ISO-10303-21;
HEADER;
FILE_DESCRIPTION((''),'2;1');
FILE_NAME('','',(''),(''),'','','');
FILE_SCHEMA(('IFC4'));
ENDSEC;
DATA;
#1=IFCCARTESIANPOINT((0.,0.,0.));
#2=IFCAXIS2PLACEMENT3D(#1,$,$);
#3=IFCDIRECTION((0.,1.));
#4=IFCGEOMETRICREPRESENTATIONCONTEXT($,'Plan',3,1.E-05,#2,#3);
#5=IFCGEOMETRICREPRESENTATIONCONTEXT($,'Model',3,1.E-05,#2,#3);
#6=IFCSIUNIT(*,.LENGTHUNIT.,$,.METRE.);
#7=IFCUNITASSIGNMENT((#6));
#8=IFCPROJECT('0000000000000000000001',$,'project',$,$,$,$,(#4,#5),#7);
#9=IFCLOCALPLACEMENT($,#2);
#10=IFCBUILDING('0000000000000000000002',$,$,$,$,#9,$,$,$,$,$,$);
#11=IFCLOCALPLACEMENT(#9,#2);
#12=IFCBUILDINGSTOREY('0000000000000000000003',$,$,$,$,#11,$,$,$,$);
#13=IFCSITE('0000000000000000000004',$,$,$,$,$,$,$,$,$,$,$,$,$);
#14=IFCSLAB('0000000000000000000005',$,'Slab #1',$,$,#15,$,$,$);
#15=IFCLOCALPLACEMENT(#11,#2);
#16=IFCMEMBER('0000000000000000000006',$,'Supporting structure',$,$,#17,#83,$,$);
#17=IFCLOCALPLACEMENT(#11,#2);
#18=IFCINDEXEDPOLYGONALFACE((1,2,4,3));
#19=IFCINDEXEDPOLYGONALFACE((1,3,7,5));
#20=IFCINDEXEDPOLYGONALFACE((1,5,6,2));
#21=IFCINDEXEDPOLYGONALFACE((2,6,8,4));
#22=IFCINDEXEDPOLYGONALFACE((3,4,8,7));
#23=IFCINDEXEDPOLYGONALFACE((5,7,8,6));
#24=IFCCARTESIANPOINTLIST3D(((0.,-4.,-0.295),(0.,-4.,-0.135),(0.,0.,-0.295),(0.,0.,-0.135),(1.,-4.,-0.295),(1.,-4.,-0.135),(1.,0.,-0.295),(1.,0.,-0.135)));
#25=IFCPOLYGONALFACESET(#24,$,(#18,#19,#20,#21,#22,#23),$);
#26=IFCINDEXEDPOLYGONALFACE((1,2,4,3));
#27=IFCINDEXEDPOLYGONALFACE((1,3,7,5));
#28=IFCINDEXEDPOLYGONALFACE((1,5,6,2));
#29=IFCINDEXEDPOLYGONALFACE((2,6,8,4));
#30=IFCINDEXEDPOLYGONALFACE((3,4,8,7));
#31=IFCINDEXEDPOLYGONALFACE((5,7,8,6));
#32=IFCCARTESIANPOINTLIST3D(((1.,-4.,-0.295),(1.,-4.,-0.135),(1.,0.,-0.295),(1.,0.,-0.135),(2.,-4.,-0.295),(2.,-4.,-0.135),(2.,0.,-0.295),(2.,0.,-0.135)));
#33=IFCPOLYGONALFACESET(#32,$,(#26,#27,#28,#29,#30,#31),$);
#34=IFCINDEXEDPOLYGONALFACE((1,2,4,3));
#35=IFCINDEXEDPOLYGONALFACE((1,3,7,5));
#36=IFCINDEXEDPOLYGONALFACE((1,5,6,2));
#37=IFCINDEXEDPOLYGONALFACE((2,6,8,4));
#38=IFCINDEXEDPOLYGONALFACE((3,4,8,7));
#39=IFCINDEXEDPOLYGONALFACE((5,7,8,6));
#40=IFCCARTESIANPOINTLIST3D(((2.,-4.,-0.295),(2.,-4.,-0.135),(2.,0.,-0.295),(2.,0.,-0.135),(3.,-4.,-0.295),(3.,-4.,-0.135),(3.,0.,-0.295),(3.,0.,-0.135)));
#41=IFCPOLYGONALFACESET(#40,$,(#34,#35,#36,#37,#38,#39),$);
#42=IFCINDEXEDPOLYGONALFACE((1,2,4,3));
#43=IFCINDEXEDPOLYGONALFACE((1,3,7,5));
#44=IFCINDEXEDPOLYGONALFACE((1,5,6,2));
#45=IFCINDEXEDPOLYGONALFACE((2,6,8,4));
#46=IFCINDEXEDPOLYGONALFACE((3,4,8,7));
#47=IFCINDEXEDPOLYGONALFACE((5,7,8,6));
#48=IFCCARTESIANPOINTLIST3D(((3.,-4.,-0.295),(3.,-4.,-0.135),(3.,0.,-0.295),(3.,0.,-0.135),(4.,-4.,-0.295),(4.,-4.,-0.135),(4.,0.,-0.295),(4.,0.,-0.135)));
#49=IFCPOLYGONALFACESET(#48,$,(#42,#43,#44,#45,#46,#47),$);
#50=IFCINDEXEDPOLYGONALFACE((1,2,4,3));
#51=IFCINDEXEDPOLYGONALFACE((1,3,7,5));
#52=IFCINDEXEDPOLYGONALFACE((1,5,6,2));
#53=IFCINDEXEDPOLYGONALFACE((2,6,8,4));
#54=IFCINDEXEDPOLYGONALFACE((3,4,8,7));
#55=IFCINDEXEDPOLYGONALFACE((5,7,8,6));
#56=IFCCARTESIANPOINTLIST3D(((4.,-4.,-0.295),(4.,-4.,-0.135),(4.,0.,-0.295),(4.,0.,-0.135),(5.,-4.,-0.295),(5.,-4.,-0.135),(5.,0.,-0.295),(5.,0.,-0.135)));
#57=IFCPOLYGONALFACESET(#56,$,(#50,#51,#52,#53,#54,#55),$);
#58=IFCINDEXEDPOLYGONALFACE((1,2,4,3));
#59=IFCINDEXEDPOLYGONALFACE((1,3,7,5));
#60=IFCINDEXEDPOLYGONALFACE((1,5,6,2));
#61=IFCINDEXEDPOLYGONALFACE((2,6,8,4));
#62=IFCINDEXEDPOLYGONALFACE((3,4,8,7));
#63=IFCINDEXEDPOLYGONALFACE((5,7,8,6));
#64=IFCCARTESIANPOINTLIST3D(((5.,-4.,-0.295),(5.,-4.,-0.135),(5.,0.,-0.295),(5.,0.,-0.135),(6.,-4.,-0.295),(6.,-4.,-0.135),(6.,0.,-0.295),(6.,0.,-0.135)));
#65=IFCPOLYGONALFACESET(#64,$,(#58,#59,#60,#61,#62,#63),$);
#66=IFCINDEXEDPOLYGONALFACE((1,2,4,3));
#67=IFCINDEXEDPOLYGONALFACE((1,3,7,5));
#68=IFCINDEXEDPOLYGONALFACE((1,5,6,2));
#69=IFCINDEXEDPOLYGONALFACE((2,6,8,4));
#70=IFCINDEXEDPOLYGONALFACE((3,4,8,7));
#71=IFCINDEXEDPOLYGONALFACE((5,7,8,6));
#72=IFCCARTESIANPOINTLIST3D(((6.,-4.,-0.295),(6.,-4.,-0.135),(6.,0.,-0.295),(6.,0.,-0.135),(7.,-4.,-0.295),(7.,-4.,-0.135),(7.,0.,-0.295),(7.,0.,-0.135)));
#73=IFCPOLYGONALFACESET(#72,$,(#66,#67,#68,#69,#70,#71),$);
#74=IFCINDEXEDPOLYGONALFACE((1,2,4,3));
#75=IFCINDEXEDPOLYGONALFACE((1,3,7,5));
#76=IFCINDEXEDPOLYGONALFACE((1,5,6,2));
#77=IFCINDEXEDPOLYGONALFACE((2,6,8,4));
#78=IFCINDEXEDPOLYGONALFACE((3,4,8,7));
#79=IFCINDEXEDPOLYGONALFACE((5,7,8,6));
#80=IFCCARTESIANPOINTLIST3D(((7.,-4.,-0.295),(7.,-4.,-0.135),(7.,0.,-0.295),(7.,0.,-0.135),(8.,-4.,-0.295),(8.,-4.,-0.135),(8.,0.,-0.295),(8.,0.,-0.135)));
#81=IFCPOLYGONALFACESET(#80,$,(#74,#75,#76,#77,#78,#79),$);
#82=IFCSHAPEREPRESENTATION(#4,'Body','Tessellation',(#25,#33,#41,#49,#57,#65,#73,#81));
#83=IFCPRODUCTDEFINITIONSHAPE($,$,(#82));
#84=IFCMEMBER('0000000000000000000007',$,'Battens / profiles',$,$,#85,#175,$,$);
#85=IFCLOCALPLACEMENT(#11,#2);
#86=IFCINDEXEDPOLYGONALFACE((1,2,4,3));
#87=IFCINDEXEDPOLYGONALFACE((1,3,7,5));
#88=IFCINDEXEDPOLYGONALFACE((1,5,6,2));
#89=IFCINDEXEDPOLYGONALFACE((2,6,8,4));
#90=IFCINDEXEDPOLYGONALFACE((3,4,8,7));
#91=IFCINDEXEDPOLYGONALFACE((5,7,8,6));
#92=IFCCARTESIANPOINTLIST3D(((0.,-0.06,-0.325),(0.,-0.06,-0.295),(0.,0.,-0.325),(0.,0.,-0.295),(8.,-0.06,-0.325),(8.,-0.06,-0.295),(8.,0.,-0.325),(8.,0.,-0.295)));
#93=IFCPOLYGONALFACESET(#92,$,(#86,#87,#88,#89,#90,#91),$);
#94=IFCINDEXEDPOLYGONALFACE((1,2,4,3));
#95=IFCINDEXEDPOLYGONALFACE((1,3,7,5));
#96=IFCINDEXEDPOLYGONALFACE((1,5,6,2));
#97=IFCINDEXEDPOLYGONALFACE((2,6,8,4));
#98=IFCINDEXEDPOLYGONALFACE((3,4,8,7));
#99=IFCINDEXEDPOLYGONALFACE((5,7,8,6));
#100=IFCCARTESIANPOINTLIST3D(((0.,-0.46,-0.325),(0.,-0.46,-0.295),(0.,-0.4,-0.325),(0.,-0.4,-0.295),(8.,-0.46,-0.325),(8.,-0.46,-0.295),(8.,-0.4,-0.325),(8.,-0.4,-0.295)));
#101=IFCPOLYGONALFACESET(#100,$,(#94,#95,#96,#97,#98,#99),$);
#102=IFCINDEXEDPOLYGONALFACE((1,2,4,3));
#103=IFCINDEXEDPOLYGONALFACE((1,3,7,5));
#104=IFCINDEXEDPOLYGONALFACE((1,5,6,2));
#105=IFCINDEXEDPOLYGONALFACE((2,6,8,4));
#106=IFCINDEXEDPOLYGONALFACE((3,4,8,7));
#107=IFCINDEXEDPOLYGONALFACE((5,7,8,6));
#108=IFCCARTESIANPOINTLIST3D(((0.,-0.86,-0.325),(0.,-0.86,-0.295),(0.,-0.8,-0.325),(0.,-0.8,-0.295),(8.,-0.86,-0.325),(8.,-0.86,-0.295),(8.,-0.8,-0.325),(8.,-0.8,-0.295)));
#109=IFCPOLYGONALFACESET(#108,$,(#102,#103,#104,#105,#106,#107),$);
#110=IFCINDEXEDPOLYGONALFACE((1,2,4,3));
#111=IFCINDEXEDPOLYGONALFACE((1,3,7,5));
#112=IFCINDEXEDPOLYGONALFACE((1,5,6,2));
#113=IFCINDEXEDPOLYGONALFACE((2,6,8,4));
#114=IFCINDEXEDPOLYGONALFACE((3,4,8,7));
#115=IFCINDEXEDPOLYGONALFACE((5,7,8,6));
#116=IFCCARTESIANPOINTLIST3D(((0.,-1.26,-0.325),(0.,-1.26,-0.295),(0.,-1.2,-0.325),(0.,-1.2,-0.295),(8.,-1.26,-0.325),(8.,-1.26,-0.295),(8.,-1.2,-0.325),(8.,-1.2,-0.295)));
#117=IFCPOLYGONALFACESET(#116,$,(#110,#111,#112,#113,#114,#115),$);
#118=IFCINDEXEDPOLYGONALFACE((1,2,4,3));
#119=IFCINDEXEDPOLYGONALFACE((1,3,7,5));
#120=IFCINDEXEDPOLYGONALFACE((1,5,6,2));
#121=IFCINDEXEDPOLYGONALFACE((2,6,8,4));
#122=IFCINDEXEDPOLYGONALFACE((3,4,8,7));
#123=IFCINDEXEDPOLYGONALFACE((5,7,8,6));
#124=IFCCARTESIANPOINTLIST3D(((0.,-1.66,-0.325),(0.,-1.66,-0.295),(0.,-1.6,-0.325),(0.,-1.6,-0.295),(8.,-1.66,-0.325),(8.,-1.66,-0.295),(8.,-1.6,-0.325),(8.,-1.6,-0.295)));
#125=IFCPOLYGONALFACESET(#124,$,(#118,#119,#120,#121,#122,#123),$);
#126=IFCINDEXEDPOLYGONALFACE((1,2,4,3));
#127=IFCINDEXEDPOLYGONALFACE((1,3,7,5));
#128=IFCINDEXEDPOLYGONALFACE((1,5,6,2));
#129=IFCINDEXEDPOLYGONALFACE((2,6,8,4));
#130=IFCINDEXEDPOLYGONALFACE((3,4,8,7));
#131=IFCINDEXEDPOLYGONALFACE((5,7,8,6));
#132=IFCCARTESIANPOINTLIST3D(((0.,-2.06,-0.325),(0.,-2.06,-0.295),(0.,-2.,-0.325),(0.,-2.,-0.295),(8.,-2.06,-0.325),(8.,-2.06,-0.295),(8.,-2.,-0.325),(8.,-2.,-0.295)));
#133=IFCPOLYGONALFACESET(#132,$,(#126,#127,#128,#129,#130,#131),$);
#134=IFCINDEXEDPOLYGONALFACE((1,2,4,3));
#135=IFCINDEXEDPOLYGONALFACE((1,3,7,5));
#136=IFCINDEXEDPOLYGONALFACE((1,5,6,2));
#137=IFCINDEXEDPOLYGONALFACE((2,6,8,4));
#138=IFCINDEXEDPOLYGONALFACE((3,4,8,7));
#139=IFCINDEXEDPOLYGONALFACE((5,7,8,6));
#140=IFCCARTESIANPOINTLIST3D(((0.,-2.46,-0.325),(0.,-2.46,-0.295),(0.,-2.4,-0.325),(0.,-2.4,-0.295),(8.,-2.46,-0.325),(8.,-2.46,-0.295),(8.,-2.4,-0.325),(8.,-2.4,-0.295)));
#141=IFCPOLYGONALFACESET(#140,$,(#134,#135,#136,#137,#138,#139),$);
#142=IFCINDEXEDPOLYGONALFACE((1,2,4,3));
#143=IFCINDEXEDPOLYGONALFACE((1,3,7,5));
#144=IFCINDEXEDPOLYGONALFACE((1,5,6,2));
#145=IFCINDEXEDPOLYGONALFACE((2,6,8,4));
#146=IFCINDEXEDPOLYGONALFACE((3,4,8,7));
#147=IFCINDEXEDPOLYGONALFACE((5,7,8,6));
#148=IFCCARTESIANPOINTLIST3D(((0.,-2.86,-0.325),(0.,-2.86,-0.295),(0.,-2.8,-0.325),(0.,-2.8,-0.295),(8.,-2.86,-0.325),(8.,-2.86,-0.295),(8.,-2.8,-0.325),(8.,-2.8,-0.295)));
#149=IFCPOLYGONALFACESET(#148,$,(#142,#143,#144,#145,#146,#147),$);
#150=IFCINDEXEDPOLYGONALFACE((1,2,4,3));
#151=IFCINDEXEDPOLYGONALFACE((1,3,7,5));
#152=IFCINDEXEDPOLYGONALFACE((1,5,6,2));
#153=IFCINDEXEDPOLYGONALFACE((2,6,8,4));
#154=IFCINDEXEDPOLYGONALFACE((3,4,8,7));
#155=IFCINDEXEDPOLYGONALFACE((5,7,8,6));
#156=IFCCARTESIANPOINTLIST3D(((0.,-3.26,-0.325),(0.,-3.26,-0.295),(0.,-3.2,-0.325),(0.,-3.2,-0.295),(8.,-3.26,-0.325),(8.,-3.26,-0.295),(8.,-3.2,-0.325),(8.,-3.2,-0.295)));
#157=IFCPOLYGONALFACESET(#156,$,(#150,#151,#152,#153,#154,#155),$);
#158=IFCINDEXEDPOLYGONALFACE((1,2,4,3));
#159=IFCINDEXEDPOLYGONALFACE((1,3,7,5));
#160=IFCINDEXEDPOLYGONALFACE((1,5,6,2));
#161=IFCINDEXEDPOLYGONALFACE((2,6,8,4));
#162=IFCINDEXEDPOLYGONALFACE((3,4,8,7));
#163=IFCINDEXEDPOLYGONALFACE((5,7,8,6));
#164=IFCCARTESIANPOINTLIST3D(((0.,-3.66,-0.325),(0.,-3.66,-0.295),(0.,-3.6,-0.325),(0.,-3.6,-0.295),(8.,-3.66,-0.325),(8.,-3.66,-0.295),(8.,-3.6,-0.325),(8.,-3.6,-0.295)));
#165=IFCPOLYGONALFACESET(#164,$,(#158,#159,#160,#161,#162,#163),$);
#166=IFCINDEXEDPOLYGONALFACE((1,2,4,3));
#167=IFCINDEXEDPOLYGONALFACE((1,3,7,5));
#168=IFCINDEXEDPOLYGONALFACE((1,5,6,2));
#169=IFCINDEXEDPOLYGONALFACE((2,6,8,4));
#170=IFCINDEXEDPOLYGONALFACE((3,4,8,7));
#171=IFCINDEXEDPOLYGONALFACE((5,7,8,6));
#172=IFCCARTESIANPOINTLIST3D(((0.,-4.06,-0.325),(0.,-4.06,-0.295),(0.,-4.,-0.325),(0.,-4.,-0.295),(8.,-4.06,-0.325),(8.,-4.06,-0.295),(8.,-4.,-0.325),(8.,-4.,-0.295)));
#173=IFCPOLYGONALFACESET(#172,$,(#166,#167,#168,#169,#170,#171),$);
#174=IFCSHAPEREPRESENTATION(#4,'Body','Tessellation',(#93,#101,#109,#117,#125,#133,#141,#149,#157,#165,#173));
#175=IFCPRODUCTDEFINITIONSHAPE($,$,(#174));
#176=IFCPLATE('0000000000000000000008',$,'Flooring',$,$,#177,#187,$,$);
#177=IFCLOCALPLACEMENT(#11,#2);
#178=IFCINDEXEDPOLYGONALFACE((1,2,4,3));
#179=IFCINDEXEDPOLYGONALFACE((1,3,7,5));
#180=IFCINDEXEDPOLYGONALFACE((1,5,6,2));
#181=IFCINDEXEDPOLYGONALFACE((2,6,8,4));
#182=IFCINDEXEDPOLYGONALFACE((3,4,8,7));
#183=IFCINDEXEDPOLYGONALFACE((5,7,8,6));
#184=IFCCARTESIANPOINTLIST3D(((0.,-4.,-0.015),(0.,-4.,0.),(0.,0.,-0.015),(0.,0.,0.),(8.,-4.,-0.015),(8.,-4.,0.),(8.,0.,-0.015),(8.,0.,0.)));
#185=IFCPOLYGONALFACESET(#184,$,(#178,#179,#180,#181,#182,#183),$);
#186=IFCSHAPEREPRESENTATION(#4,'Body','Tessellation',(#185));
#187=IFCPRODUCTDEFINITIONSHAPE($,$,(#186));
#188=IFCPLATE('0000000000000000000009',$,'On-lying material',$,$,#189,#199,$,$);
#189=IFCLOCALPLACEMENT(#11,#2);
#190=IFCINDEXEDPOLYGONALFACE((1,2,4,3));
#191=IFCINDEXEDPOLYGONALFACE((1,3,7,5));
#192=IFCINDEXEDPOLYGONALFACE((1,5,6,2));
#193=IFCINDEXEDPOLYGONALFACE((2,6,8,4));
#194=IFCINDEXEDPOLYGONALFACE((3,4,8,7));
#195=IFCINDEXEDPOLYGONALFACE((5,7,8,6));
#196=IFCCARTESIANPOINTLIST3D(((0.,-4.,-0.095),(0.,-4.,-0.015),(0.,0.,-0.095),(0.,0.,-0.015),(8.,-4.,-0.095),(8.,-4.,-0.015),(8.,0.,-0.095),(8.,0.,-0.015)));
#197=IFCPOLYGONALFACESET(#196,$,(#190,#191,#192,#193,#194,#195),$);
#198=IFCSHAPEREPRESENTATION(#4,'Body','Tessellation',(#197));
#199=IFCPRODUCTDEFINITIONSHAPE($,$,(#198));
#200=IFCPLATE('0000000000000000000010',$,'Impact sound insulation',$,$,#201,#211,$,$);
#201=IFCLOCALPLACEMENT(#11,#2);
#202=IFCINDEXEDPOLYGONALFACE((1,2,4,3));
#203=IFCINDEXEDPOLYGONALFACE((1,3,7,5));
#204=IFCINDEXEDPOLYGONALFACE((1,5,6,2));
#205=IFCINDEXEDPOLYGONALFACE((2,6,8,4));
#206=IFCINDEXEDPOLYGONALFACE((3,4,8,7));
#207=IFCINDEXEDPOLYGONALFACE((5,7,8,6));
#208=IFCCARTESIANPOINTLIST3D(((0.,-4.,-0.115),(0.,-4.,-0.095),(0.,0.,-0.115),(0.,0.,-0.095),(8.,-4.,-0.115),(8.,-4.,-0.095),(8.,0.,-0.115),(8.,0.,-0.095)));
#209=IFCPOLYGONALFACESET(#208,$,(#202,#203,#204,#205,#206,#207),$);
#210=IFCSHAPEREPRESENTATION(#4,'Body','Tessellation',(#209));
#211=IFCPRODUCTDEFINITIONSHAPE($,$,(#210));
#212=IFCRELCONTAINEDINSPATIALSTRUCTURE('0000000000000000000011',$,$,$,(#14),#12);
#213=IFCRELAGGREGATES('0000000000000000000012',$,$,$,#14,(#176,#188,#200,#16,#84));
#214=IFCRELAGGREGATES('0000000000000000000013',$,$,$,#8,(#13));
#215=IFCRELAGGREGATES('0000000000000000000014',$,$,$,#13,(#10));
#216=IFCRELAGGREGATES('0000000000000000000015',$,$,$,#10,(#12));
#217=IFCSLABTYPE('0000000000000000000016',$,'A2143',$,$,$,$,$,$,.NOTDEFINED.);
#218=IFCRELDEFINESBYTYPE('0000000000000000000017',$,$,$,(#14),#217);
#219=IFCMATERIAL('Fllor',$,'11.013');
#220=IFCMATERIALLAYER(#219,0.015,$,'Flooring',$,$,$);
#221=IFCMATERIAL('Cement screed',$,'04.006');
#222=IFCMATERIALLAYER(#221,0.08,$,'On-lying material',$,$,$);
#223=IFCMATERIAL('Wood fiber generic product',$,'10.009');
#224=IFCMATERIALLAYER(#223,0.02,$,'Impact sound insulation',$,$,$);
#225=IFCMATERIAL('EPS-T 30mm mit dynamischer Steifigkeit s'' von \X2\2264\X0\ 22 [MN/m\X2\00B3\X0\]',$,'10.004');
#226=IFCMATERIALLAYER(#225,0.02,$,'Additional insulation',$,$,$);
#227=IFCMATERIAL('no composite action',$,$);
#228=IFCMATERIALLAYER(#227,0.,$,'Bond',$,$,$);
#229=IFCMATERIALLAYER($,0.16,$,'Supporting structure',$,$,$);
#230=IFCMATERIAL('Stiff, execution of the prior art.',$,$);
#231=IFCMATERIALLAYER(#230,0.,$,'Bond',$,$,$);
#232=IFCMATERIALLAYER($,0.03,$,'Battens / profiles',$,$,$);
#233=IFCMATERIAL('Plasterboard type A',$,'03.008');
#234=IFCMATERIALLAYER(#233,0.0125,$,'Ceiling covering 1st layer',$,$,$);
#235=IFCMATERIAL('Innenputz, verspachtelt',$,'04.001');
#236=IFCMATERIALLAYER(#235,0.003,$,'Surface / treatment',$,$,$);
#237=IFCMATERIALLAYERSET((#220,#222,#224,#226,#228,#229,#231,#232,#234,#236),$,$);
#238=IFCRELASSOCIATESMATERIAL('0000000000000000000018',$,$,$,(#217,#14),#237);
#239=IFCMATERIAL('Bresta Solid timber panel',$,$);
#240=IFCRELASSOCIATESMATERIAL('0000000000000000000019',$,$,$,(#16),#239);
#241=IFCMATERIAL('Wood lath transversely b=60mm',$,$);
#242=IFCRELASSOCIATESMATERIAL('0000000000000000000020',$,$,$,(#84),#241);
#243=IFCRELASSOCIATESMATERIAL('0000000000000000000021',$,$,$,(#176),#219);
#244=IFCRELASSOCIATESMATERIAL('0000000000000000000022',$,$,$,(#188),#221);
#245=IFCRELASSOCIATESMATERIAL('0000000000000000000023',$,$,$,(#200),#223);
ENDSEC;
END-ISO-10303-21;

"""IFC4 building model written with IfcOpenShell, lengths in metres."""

from ifc_helpers import new_model, si_unit, direction, frame, frame_2d, origin, origin_with_axes, place, context, project, spatial, rectangle, extrude, material, layer, layer_set, type_object, element, aggregate, save


model = new_model("IFC4")

# Units and contexts
plan_context = context("Plan", 3, precision=1e-05, world=origin(), true_north=direction((0.0, 1.0)))
model_context = context("Model", 3, precision=1e-05, world=origin(), true_north=direction((0.0, 1.0)))
ifc_project = project(units=[si_unit("LENGTHUNIT", "METRE")], contexts=[plan_context, model_context])

# Site, building, storey
site = spatial("IfcSite", under=ifc_project)
building_placement = place(None, origin())
building = spatial("IfcBuilding", under=site, at=building_placement)
storey_placement = place(building_placement, origin())
storey = spatial("IfcBuildingStorey", under=building, at=storey_placement)

# Slab, members, plates
ifc_material_1 = material(Name="Fllor", Category="11.013")
ifc_layer_1 = layer(ifc_material_1, 0.015, Name="Flooring")
ifc_material_2 = material(Name="Cement screed", Category="04.006")
ifc_layer_2 = layer(ifc_material_2, 0.08, Name="On-lying material")
ifc_material_3 = material(Name="Wood fiber generic product", Category="10.009")
ifc_layer_3 = layer(ifc_material_3, 0.02, Name="Impact sound insulation")
ifc_material_4 = material(Name="EPS-T 30mm mit dynamischer Steifigkeit s' von ≤ 22 [MN/m³]", Category="10.004")
ifc_layer_4 = layer(ifc_material_4, 0.02, Name="Additional insulation")
ifc_material_5 = material(Name="no composite action")
ifc_layer_5 = layer(ifc_material_5, 0.0, Name="Bond")
ifc_layer_6 = layer(None, 0.16, Name="Supporting structure")
ifc_material_6 = material(Name="Stiff, execution of the prior art.")
ifc_layer_7 = layer(ifc_material_6, 0.0, Name="Bond")
ifc_layer_8 = layer(None, 0.03, Name="Battens / profiles")
ifc_material_7 = material(Name="Plasterboard type A", Category="03.008")
ifc_layer_9 = layer(ifc_material_7, 0.0125, Name="Ceiling covering 1st layer")
ifc_material_8 = material(Name="Innenputz, verspachtelt", Category="04.001")
ifc_layer_10 = layer(ifc_material_8, 0.003, Name="Surface / treatment")
ifc_layer_set = layer_set([ifc_layer_1, ifc_layer_2, ifc_layer_3, ifc_layer_4, ifc_layer_5, ifc_layer_6, ifc_layer_7, ifc_layer_8, ifc_layer_9, ifc_layer_10])
slab_type = type_object("IfcSlabType", Name="A2143", PredefinedType="NOTDEFINED", material=ifc_layer_set)
slab_placement = place(None, frame((0.0, 0.0, 0.0), z_axis=(0.0, 0.0, -1.0), x_axis=(1.0, 0.0, 0.0)))
slab = element("IfcSlab", 1, at=slab_placement, inside=storey, type_object=slab_type, material=ifc_layer_set, Name="Slab #1")
ifc_material_9 = material(Name="Bresta Solid timber panel")
member_1_placement = place(slab_placement, origin())
member_1 = element("IfcMember", 2, at=member_1_placement, material=ifc_material_9, Name="Supporting structure", context=plan_context, shape_type="SweptSolid", body=[
    extrude(rectangle(XDim=1.0, YDim=0.16, at=frame_2d((0.5, 0.08), x_axis=(1.0, 0.0))), frame((0.0, 4.0, 0.135), z_axis=(0.0, -1.0, 0.0), x_axis=(1.0, 0.0, 0.0)), (0.0, 0.0, 1.0), 4.0),
    extrude(rectangle(XDim=1.0, YDim=0.16, at=frame_2d((0.5, 0.08), x_axis=(1.0, 0.0))), frame((1.0, 4.0, 0.135), z_axis=(0.0, -1.0, 0.0), x_axis=(1.0, 0.0, 0.0)), (0.0, 0.0, 1.0), 4.0),
    extrude(rectangle(XDim=1.0, YDim=0.16, at=frame_2d((0.5, 0.08), x_axis=(1.0, 0.0))), frame((2.0, 4.0, 0.135), z_axis=(0.0, -1.0, 0.0), x_axis=(1.0, 0.0, 0.0)), (0.0, 0.0, 1.0), 4.0),
    extrude(rectangle(XDim=1.0, YDim=0.16, at=frame_2d((0.5, 0.08), x_axis=(1.0, 0.0))), frame((3.0, 4.0, 0.135), z_axis=(0.0, -1.0, 0.0), x_axis=(1.0, 0.0, 0.0)), (0.0, 0.0, 1.0), 4.0),
    extrude(rectangle(XDim=1.0, YDim=0.16, at=frame_2d((0.5, 0.08), x_axis=(1.0, 0.0))), frame((4.0, 4.0, 0.135), z_axis=(0.0, -1.0, 0.0), x_axis=(1.0, 0.0, 0.0)), (0.0, 0.0, 1.0), 4.0),
    extrude(rectangle(XDim=1.0, YDim=0.16, at=frame_2d((0.5, 0.08), x_axis=(1.0, 0.0))), frame((5.0, 4.0, 0.135), z_axis=(0.0, -1.0, 0.0), x_axis=(1.0, 0.0, 0.0)), (0.0, 0.0, 1.0), 4.0),
    extrude(rectangle(XDim=1.0, YDim=0.16, at=frame_2d((0.5, 0.08), x_axis=(1.0, 0.0))), frame((6.0, 4.0, 0.135), z_axis=(0.0, -1.0, 0.0), x_axis=(1.0, 0.0, 0.0)), (0.0, 0.0, 1.0), 4.0),
    extrude(rectangle(XDim=1.0, YDim=0.16, at=frame_2d((0.5, 0.08), x_axis=(1.0, 0.0))), frame((7.0, 4.0, 0.135), z_axis=(0.0, -1.0, 0.0), x_axis=(1.0, 0.0, 0.0)), (0.0, 0.0, 1.0), 4.0),
])
ifc_material_10 = material(Name="Wood lath transversely b=60mm")
member_2_placement = place(slab_placement, origin())
member_2 = element("IfcMember", 3, at=member_2_placement, material=ifc_material_10, Name="Battens / profiles", context=plan_context, shape_type="SweptSolid", body=[
    extrude(rectangle(XDim=0.06, YDim=0.03, at=frame_2d((0.03, 0.015), x_axis=(1.0, 0.0))), frame((0.0, 0.0, 0.295), z_axis=(1.0, 0.0, 0.0), x_axis=(0.0, 1.0, 0.0)), (0.0, 0.0, 1.0), 8.0),
    extrude(rectangle(XDim=0.06, YDim=0.03, at=frame_2d((0.03, 0.015), x_axis=(1.0, 0.0))), frame((0.0, 0.4, 0.295), z_axis=(1.0, 0.0, 0.0), x_axis=(0.0, 1.0, 0.0)), (0.0, 0.0, 1.0), 8.0),
    extrude(rectangle(XDim=0.06, YDim=0.03, at=frame_2d((0.03, 0.015), x_axis=(1.0, 0.0))), frame((0.0, 0.8, 0.295), z_axis=(1.0, 0.0, 0.0), x_axis=(0.0, 1.0, 0.0)), (0.0, 0.0, 1.0), 8.0),
    extrude(rectangle(XDim=0.06, YDim=0.03, at=frame_2d((0.03, 0.015), x_axis=(1.0, 0.0))), frame((0.0, 1.2, 0.295), z_axis=(1.0, 0.0, 0.0), x_axis=(0.0, 1.0, 0.0)), (0.0, 0.0, 1.0), 8.0),
    extrude(rectangle(XDim=0.06, YDim=0.03, at=frame_2d((0.03, 0.015), x_axis=(1.0, 0.0))), frame((0.0, 1.6, 0.295), z_axis=(1.0, 0.0, 0.0), x_axis=(0.0, 1.0, 0.0)), (0.0, 0.0, 1.0), 8.0),
    extrude(rectangle(XDim=0.06, YDim=0.03, at=frame_2d((0.03, 0.015), x_axis=(1.0, 0.0))), frame((0.0, 2.0, 0.295), z_axis=(1.0, 0.0, 0.0), x_axis=(0.0, 1.0, 0.0)), (0.0, 0.0, 1.0), 8.0),
    extrude(rectangle(XDim=0.06, YDim=0.03, at=frame_2d((0.03, 0.015), x_axis=(1.0, 0.0))), frame((0.0, 2.4, 0.295), z_axis=(1.0, 0.0, 0.0), x_axis=(0.0, 1.0, 0.0)), (0.0, 0.0, 1.0), 8.0),
    extrude(rectangle(XDim=0.06, YDim=0.03, at=frame_2d((0.03, 0.015), x_axis=(1.0, 0.0))), frame((0.0, 2.8, 0.295), z_axis=(1.0, 0.0, 0.0), x_axis=(0.0, 1.0, 0.0)), (0.0, 0.0, 1.0), 8.0),
    extrude(rectangle(XDim=0.06, YDim=0.03, at=frame_2d((0.03, 0.015), x_axis=(1.0, 0.0))), frame((0.0, 3.2, 0.295), z_axis=(1.0, 0.0, 0.0), x_axis=(0.0, 1.0, 0.0)), (0.0, 0.0, 1.0), 8.0),
    extrude(rectangle(XDim=0.06, YDim=0.03, at=frame_2d((0.03, 0.015), x_axis=(1.0, 0.0))), frame((0.0, 3.6, 0.295), z_axis=(1.0, 0.0, 0.0), x_axis=(0.0, 1.0, 0.0)), (0.0, 0.0, 1.0), 8.0),
    extrude(rectangle(XDim=0.06, YDim=0.03, at=frame_2d((0.03, 0.015), x_axis=(1.0, 0.0))), frame((0.0, 4.0, 0.295), z_axis=(1.0, 0.0, 0.0), x_axis=(0.0, 1.0, 0.0)), (0.0, 0.0, 1.0), 8.0),
])
plate_1_placement = place(slab_placement, origin())
plate_1 = element("IfcPlate", 4, at=plate_1_placement, material=ifc_material_1, Name="Flooring", context=plan_context, shape_type="SweptSolid", body=[
    extrude(rectangle(XDim=8.0, YDim=4.0, at=frame_2d((4.0, 2.0), x_axis=(1.0, 0.0))), origin_with_axes(), (0.0, 0.0, 1.0), 0.015),
])
plate_2_placement = place(slab_placement, origin())
plate_2 = element("IfcPlate", 5, at=plate_2_placement, material=ifc_material_2, Name="On-lying material", context=plan_context, shape_type="SweptSolid", body=[
    extrude(rectangle(XDim=8.0, YDim=4.0, at=frame_2d((4.0, 2.0), x_axis=(1.0, 0.0))), frame((0.0, 0.0, 0.015), z_axis=(0.0, 0.0, 1.0), x_axis=(1.0, 0.0, 0.0)), (0.0, 0.0, 1.0), 0.08),
])
plate_3_placement = place(slab_placement, origin())
plate_3 = element("IfcPlate", 6, at=plate_3_placement, material=ifc_material_3, Name="Impact sound insulation", context=plan_context, shape_type="SweptSolid", body=[
    extrude(rectangle(XDim=8.0, YDim=4.0, at=frame_2d((4.0, 2.0), x_axis=(1.0, 0.0))), frame((0.0, 0.0, 0.095), z_axis=(0.0, 0.0, 1.0), x_axis=(1.0, 0.0, 0.0)), (0.0, 0.0, 1.0), 0.02),
])
aggregate(slab, [plate_1, plate_2, plate_3, member_1, member_2])

save(model, "model.ifc")
